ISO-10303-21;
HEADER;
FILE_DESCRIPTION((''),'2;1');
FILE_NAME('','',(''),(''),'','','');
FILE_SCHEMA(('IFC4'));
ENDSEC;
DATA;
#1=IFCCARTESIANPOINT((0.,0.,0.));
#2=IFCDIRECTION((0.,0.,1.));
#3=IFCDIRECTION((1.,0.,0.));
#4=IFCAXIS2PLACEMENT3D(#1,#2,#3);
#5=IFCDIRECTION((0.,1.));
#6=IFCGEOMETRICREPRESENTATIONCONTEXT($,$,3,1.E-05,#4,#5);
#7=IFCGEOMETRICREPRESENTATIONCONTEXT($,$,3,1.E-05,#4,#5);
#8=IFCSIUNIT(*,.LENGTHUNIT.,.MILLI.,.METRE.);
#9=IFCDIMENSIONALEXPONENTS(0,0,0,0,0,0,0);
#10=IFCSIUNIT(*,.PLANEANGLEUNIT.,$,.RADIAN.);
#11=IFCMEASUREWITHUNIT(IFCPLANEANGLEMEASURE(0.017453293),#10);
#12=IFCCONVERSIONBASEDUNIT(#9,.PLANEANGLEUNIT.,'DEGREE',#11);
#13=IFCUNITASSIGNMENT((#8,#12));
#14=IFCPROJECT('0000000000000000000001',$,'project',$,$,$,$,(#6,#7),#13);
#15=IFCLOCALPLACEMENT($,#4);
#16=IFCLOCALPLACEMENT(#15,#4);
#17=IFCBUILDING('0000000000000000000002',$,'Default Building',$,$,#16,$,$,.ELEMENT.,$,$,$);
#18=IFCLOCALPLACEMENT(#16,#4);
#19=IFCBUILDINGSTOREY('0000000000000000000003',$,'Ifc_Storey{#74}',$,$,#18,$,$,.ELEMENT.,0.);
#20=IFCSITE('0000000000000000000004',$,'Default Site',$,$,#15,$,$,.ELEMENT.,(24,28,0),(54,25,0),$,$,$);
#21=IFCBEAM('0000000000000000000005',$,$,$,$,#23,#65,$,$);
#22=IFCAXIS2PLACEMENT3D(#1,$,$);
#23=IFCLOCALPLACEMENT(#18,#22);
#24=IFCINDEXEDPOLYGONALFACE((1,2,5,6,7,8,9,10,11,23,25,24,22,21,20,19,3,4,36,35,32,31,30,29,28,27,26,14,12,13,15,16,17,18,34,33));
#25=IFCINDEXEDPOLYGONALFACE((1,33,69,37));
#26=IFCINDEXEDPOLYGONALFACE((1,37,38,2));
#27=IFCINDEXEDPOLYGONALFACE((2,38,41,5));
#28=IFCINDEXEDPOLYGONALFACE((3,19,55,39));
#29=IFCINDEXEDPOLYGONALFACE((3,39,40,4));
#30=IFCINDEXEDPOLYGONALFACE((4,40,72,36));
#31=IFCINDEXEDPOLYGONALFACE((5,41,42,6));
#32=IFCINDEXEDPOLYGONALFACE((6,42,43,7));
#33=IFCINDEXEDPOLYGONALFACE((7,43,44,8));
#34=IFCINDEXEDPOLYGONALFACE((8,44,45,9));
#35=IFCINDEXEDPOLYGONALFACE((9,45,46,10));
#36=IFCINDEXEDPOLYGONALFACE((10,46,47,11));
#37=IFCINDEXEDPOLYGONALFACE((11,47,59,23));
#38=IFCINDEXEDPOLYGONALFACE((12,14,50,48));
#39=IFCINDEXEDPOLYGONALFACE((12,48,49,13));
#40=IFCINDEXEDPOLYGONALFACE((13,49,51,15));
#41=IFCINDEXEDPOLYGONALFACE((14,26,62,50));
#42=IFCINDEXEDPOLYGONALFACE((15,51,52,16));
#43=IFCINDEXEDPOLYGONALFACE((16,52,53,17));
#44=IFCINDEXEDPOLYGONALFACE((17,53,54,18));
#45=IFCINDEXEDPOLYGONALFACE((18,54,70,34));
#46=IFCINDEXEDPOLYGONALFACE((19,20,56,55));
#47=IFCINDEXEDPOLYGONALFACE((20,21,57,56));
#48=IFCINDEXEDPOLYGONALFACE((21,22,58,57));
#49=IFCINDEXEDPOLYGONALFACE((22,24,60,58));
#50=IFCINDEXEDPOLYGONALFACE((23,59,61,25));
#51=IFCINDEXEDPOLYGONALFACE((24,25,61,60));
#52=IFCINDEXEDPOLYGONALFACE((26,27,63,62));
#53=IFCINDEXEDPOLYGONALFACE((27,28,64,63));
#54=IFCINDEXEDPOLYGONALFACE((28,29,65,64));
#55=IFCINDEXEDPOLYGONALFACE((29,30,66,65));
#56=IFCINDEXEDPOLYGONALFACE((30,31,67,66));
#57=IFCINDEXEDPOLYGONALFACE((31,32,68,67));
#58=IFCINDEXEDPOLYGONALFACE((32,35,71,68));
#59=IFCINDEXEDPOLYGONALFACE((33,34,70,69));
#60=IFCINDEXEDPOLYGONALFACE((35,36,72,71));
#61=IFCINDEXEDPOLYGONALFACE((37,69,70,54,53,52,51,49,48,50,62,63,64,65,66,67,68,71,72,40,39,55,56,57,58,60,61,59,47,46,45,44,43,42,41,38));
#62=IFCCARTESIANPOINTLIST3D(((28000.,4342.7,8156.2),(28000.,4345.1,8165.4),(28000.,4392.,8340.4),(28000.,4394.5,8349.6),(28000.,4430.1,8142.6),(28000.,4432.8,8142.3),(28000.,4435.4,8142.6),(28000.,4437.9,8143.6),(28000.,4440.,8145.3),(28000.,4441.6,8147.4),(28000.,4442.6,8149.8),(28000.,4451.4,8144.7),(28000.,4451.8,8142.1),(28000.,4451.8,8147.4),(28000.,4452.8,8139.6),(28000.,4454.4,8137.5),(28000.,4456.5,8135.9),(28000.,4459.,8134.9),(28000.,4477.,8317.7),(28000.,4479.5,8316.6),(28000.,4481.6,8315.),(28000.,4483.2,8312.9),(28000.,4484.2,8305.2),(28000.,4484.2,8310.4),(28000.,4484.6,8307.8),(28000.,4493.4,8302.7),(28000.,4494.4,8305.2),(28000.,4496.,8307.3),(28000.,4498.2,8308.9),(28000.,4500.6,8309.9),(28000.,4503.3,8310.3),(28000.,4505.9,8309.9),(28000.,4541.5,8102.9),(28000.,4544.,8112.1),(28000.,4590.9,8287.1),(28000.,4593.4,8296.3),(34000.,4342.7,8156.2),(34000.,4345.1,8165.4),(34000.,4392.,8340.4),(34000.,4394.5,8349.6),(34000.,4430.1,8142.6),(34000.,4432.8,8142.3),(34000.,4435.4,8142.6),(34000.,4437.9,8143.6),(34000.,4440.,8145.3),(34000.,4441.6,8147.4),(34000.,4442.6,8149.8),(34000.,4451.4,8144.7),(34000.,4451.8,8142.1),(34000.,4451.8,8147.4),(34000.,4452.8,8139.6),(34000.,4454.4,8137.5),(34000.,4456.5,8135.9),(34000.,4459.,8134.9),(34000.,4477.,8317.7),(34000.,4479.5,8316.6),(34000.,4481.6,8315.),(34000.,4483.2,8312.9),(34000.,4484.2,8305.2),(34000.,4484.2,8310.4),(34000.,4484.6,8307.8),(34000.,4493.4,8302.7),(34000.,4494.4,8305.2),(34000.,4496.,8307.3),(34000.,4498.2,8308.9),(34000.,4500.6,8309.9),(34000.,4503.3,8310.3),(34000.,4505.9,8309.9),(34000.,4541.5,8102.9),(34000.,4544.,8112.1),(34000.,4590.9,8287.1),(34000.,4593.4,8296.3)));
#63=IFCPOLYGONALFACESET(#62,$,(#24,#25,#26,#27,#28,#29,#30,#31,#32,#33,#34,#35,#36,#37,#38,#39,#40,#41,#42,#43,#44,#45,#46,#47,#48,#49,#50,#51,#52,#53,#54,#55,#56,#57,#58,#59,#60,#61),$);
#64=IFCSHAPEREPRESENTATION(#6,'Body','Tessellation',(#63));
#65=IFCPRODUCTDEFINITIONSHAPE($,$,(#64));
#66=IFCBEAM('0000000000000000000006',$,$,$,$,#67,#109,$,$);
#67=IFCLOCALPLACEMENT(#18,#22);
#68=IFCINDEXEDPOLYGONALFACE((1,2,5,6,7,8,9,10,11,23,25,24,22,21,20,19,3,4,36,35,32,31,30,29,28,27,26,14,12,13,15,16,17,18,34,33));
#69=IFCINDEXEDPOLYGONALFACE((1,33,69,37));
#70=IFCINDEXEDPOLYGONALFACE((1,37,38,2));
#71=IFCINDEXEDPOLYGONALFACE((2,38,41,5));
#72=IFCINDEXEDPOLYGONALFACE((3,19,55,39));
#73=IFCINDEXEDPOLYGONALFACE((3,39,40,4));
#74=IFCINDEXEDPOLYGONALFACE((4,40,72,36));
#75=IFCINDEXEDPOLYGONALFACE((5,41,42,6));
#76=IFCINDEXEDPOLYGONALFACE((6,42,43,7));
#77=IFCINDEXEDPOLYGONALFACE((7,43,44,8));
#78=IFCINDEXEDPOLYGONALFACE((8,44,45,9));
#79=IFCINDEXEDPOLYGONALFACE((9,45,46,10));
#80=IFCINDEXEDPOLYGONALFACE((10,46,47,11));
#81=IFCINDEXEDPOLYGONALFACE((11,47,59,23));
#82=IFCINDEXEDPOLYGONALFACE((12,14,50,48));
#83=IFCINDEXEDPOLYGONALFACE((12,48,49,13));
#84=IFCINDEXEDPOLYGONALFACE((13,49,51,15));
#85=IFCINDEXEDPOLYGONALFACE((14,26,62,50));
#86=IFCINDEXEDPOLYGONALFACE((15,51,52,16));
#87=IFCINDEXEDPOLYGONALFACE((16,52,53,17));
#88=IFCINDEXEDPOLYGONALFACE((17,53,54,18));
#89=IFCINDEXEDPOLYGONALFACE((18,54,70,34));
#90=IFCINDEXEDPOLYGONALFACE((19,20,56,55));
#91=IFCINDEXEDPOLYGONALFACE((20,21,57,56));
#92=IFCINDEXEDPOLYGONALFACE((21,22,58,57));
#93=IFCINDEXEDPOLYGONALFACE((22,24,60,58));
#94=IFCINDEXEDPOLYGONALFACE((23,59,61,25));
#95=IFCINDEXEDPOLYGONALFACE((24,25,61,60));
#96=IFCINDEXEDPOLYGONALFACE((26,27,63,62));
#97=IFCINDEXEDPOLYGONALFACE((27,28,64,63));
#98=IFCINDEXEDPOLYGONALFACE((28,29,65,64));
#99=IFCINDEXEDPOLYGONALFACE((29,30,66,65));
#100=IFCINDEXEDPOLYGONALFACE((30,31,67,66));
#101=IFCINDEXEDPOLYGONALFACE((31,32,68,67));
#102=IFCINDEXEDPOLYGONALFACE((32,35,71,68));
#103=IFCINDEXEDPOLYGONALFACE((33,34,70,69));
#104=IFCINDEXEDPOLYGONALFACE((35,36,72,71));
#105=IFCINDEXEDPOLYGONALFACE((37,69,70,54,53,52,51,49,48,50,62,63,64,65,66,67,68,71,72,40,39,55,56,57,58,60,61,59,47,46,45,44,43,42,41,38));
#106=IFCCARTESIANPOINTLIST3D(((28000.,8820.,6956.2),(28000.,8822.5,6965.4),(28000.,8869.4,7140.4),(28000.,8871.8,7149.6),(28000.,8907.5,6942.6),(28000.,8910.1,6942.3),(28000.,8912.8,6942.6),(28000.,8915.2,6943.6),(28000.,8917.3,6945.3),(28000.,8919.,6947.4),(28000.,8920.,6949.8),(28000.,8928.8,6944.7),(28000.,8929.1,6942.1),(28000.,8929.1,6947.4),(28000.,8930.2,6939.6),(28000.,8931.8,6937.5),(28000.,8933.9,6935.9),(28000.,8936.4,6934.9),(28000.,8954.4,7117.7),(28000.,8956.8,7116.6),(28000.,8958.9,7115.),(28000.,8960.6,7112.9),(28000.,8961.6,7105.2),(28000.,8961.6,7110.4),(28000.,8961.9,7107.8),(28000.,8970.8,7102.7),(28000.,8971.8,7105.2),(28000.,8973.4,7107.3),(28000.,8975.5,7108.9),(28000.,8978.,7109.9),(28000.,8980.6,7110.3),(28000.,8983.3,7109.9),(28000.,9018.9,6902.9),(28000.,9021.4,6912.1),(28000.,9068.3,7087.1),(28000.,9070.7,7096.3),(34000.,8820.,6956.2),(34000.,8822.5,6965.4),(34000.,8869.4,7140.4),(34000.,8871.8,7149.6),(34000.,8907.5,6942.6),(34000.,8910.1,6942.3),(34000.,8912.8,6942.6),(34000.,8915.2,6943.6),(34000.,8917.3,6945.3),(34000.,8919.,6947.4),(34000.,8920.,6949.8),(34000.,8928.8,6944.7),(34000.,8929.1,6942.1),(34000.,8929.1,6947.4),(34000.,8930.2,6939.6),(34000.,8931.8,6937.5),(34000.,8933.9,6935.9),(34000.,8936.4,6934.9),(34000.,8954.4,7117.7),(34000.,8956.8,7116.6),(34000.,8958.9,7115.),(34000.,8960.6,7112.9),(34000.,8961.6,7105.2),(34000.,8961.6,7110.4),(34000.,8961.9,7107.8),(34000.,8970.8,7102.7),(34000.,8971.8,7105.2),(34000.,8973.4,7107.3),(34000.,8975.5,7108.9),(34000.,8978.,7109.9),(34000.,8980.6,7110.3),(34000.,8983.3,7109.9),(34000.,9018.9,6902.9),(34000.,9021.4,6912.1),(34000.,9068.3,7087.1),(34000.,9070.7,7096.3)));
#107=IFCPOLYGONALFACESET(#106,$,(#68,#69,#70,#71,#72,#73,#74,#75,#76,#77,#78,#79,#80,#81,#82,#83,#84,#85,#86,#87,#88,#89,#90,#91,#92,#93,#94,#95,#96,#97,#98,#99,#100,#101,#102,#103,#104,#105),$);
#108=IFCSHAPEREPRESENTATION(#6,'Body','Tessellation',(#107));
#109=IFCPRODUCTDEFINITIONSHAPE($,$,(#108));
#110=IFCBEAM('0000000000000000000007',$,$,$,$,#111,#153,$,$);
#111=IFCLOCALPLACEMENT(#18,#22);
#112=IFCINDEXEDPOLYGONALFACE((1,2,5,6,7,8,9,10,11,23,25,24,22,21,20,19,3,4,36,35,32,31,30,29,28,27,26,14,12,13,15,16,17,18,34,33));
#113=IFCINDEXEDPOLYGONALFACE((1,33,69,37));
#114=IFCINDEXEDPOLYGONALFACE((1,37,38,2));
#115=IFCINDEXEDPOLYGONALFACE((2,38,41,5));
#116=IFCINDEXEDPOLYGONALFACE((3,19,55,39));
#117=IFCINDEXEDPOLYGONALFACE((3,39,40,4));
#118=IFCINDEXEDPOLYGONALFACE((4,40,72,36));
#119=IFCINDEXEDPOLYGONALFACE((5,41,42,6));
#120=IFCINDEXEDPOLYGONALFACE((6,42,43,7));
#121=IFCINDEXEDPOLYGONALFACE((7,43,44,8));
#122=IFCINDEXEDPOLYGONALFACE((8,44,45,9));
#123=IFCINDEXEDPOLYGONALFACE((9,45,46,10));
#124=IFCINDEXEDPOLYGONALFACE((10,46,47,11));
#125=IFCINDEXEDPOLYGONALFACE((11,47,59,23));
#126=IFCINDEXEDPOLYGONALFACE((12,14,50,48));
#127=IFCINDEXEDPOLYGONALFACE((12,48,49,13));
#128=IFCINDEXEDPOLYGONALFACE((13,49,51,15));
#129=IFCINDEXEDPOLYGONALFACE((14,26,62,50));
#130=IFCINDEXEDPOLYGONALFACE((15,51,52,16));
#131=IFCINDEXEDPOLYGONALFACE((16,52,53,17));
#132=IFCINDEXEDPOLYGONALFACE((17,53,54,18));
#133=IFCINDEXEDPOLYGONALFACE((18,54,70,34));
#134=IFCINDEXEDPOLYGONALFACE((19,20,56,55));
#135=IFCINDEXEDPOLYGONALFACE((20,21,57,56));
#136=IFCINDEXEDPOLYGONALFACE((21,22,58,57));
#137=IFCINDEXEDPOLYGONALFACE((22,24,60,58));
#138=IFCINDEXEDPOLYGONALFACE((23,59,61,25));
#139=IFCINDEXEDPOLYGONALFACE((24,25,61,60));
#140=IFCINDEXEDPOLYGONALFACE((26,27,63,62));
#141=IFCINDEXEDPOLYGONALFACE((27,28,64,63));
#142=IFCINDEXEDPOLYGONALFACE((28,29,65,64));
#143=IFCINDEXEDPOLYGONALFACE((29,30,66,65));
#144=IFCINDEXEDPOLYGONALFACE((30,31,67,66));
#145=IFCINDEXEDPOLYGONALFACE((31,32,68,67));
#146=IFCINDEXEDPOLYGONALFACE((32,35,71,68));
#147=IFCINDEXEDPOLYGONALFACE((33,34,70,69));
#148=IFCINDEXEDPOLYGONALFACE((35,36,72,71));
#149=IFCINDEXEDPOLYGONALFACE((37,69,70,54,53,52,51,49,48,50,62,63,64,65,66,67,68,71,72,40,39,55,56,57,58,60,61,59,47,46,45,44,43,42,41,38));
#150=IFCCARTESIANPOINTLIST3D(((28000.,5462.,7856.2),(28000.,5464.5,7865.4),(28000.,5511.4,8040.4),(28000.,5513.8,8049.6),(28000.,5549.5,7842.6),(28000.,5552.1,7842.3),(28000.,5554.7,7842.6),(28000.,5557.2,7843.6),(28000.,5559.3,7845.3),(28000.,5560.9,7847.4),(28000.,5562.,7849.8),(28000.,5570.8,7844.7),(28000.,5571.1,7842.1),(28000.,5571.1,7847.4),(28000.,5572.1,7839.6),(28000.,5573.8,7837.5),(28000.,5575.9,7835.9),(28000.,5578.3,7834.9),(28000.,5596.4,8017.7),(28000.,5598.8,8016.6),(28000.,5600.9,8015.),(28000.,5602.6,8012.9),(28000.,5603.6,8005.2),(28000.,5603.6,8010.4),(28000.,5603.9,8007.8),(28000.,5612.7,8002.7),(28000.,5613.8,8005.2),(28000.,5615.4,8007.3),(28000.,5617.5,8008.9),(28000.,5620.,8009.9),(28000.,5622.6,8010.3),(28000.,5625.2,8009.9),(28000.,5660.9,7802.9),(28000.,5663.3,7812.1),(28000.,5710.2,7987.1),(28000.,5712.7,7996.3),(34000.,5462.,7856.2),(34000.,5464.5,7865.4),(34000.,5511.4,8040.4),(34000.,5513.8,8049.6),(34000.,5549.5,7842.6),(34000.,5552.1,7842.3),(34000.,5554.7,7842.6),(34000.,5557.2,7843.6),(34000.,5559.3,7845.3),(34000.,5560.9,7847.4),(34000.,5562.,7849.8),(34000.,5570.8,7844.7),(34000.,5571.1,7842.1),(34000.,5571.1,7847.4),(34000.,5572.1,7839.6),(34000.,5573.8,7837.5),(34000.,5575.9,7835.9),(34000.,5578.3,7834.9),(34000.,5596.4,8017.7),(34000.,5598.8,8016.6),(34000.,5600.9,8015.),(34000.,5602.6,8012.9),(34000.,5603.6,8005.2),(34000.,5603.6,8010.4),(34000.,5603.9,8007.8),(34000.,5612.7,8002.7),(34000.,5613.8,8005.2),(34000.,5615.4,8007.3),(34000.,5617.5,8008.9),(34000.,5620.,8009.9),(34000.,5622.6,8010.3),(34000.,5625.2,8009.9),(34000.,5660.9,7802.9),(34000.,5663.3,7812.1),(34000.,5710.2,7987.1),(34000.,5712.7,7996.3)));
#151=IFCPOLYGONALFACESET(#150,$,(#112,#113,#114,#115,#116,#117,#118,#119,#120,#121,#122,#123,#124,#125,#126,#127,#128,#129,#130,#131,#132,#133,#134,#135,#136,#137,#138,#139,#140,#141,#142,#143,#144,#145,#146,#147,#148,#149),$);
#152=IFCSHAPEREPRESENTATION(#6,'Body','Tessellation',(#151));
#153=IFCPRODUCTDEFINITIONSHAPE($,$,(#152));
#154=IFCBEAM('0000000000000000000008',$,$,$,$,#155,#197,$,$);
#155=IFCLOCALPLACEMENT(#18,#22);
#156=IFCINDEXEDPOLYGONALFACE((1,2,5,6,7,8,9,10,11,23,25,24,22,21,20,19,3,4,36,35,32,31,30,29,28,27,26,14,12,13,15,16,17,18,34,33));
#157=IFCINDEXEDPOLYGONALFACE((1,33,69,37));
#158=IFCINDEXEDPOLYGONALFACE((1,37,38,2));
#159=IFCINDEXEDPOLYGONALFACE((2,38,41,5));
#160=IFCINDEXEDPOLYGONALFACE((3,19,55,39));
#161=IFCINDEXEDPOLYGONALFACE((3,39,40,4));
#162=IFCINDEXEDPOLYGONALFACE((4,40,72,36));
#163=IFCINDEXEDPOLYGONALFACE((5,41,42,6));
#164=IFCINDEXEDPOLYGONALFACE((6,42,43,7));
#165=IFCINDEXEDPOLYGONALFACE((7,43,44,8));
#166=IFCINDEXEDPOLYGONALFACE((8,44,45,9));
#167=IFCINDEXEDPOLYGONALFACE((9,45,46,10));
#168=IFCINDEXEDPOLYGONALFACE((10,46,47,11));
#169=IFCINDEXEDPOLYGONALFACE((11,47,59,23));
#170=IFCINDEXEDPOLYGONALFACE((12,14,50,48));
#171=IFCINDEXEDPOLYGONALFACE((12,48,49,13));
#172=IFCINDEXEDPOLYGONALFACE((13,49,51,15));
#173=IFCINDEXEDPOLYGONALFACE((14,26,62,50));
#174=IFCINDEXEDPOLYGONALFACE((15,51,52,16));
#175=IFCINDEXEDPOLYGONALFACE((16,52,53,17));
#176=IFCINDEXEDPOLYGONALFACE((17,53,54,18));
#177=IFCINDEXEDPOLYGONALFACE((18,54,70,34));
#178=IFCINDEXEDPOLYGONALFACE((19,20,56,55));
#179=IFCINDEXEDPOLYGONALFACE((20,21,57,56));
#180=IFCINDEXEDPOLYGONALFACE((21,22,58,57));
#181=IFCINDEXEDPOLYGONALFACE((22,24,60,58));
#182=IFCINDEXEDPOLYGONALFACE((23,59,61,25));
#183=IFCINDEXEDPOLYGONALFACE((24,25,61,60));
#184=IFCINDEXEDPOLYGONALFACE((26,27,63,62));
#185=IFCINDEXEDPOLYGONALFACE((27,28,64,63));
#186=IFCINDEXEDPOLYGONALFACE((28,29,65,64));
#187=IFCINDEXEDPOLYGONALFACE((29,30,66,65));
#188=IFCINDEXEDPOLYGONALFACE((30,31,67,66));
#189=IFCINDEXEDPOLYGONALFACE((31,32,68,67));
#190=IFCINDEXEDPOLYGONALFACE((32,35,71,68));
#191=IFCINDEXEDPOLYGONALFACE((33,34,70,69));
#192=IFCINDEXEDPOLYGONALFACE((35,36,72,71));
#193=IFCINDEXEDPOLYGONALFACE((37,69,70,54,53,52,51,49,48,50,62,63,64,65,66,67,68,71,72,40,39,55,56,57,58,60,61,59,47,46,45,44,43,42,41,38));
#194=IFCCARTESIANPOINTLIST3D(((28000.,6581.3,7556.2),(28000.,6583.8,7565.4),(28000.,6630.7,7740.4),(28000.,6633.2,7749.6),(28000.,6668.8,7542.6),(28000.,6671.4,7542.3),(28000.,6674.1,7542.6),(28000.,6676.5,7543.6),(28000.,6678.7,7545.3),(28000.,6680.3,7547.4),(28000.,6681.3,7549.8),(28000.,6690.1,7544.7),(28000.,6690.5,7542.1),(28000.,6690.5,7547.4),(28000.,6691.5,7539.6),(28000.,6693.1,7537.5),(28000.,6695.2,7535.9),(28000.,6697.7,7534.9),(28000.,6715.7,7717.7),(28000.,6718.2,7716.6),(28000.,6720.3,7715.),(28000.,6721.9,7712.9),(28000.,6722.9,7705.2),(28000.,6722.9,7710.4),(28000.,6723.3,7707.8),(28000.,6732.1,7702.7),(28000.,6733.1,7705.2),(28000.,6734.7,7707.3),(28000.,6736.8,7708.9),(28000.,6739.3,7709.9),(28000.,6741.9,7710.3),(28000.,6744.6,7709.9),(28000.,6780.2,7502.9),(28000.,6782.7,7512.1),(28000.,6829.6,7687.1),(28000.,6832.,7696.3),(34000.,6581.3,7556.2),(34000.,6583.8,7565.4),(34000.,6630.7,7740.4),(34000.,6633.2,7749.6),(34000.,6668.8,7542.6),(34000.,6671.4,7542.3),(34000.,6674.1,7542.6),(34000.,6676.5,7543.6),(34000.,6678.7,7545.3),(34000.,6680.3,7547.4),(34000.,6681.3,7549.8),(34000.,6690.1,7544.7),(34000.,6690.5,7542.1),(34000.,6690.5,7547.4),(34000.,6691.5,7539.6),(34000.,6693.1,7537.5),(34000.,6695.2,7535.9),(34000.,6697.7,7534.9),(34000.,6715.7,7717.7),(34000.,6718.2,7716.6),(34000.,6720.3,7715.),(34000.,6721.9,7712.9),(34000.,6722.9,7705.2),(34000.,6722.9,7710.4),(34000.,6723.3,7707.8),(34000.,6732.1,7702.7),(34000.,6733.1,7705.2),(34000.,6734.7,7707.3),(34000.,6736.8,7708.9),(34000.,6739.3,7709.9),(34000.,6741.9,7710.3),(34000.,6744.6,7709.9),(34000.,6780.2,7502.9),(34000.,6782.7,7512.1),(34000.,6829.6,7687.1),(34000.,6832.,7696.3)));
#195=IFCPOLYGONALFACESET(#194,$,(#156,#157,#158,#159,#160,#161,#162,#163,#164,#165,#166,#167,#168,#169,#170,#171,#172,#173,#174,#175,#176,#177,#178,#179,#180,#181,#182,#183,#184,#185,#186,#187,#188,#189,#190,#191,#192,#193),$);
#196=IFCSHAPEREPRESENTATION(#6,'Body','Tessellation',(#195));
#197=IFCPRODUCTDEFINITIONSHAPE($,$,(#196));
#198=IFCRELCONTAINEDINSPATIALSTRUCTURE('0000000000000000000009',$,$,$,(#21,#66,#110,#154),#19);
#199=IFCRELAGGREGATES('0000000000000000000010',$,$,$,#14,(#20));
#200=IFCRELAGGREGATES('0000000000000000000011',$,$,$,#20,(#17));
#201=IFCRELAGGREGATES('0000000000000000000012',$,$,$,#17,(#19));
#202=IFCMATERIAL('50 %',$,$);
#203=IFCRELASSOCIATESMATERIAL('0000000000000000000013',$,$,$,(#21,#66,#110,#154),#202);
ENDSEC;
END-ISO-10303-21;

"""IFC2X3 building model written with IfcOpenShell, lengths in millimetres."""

from ifc_helpers import new_model, entity, si_unit, converted_unit, direction, frame, origin_with_axes, origin_2d_with_axis, place, context, project, spatial, i_section, extrude, material, element, save


model = new_model("IFC2X3")

# Units and contexts
context_of_model_1 = context(None, 3, precision=1e-05, world=origin_with_axes(), true_north=direction((0.0, 1.0)))
context_of_model_2 = context(None, 3, precision=1e-05, world=origin_with_axes(), true_north=direction((0.0, 1.0)))
ifc_project = project(units=[si_unit("LENGTHUNIT", "METRE", prefix="MILLI"), converted_unit("PLANEANGLEUNIT", "DEGREE", entity("IfcPlaneAngleMeasure", 0.017453293), si_unit("PLANEANGLEUNIT", "RADIAN"), dimensions=[0, 0, 0, 0, 0, 0, 0])], contexts=[context_of_model_1, context_of_model_2])

# Site, building, storey
site_placement = place(None, origin_with_axes())
site = spatial("IfcSite", under=ifc_project, at=site_placement, Name="Default Site", CompositionType="ELEMENT", RefLatitude=(24, 28, 0), RefLongitude=(54, 25, 0))
building_placement = place(site_placement, origin_with_axes())
building = spatial("IfcBuilding", under=site, at=building_placement, Name="Default Building", CompositionType="ELEMENT")
storey_placement = place(building_placement, origin_with_axes())
storey = spatial("IfcBuildingStorey", under=building, at=storey_placement, Name="Ifc_Storey{#74}", CompositionType="ELEMENT", Elevation=0.0)

# Shared definitions
ifc_material_1 = material(Name="50 %")

# Beams
for number, where, z_axis, x_axis in (
    (1, (28000.0, 4468.0, 8226.3), (0.0, 0.258819, 0.965926), (1.0, 0.0, 0.0)),
    (2, (28000.0, 8945.4, 7026.3), (0.0, 0.258819, 0.965926), (1.0, 0.0, 0.0)),
    (3, (28000.0, 5587.4, 7926.3), (0.0, 0.258819, 0.965926), (1.0, 0.0, 0.0)),
    (4, (28000.0, 6706.7, 7626.3), (0.0, 0.258819, 0.965926), (1.0, 0.0, 0.0)),
):
    element("IfcBeam", number, at=place(storey_placement, frame(where, z_axis=z_axis, x_axis=x_axis)), inside=storey, material=ifc_material_1, context=context_of_model_1, shape_type="SweptSolid", body=[
        extrude(i_section(OverallWidth=205.9, OverallDepth=200.2, WebThickness=9.5, FlangeThickness=9.5, FilletRadius=10.2, at=origin_2d_with_axis()), frame((0.0, 0.0, 0.0), z_axis=(1.0, 0.0, 0.0), x_axis=(0.0, 1.0, 0.0)), (0.0, 0.0, 1.0), 6000.0),
    ])

save(model, "model.ifc")
